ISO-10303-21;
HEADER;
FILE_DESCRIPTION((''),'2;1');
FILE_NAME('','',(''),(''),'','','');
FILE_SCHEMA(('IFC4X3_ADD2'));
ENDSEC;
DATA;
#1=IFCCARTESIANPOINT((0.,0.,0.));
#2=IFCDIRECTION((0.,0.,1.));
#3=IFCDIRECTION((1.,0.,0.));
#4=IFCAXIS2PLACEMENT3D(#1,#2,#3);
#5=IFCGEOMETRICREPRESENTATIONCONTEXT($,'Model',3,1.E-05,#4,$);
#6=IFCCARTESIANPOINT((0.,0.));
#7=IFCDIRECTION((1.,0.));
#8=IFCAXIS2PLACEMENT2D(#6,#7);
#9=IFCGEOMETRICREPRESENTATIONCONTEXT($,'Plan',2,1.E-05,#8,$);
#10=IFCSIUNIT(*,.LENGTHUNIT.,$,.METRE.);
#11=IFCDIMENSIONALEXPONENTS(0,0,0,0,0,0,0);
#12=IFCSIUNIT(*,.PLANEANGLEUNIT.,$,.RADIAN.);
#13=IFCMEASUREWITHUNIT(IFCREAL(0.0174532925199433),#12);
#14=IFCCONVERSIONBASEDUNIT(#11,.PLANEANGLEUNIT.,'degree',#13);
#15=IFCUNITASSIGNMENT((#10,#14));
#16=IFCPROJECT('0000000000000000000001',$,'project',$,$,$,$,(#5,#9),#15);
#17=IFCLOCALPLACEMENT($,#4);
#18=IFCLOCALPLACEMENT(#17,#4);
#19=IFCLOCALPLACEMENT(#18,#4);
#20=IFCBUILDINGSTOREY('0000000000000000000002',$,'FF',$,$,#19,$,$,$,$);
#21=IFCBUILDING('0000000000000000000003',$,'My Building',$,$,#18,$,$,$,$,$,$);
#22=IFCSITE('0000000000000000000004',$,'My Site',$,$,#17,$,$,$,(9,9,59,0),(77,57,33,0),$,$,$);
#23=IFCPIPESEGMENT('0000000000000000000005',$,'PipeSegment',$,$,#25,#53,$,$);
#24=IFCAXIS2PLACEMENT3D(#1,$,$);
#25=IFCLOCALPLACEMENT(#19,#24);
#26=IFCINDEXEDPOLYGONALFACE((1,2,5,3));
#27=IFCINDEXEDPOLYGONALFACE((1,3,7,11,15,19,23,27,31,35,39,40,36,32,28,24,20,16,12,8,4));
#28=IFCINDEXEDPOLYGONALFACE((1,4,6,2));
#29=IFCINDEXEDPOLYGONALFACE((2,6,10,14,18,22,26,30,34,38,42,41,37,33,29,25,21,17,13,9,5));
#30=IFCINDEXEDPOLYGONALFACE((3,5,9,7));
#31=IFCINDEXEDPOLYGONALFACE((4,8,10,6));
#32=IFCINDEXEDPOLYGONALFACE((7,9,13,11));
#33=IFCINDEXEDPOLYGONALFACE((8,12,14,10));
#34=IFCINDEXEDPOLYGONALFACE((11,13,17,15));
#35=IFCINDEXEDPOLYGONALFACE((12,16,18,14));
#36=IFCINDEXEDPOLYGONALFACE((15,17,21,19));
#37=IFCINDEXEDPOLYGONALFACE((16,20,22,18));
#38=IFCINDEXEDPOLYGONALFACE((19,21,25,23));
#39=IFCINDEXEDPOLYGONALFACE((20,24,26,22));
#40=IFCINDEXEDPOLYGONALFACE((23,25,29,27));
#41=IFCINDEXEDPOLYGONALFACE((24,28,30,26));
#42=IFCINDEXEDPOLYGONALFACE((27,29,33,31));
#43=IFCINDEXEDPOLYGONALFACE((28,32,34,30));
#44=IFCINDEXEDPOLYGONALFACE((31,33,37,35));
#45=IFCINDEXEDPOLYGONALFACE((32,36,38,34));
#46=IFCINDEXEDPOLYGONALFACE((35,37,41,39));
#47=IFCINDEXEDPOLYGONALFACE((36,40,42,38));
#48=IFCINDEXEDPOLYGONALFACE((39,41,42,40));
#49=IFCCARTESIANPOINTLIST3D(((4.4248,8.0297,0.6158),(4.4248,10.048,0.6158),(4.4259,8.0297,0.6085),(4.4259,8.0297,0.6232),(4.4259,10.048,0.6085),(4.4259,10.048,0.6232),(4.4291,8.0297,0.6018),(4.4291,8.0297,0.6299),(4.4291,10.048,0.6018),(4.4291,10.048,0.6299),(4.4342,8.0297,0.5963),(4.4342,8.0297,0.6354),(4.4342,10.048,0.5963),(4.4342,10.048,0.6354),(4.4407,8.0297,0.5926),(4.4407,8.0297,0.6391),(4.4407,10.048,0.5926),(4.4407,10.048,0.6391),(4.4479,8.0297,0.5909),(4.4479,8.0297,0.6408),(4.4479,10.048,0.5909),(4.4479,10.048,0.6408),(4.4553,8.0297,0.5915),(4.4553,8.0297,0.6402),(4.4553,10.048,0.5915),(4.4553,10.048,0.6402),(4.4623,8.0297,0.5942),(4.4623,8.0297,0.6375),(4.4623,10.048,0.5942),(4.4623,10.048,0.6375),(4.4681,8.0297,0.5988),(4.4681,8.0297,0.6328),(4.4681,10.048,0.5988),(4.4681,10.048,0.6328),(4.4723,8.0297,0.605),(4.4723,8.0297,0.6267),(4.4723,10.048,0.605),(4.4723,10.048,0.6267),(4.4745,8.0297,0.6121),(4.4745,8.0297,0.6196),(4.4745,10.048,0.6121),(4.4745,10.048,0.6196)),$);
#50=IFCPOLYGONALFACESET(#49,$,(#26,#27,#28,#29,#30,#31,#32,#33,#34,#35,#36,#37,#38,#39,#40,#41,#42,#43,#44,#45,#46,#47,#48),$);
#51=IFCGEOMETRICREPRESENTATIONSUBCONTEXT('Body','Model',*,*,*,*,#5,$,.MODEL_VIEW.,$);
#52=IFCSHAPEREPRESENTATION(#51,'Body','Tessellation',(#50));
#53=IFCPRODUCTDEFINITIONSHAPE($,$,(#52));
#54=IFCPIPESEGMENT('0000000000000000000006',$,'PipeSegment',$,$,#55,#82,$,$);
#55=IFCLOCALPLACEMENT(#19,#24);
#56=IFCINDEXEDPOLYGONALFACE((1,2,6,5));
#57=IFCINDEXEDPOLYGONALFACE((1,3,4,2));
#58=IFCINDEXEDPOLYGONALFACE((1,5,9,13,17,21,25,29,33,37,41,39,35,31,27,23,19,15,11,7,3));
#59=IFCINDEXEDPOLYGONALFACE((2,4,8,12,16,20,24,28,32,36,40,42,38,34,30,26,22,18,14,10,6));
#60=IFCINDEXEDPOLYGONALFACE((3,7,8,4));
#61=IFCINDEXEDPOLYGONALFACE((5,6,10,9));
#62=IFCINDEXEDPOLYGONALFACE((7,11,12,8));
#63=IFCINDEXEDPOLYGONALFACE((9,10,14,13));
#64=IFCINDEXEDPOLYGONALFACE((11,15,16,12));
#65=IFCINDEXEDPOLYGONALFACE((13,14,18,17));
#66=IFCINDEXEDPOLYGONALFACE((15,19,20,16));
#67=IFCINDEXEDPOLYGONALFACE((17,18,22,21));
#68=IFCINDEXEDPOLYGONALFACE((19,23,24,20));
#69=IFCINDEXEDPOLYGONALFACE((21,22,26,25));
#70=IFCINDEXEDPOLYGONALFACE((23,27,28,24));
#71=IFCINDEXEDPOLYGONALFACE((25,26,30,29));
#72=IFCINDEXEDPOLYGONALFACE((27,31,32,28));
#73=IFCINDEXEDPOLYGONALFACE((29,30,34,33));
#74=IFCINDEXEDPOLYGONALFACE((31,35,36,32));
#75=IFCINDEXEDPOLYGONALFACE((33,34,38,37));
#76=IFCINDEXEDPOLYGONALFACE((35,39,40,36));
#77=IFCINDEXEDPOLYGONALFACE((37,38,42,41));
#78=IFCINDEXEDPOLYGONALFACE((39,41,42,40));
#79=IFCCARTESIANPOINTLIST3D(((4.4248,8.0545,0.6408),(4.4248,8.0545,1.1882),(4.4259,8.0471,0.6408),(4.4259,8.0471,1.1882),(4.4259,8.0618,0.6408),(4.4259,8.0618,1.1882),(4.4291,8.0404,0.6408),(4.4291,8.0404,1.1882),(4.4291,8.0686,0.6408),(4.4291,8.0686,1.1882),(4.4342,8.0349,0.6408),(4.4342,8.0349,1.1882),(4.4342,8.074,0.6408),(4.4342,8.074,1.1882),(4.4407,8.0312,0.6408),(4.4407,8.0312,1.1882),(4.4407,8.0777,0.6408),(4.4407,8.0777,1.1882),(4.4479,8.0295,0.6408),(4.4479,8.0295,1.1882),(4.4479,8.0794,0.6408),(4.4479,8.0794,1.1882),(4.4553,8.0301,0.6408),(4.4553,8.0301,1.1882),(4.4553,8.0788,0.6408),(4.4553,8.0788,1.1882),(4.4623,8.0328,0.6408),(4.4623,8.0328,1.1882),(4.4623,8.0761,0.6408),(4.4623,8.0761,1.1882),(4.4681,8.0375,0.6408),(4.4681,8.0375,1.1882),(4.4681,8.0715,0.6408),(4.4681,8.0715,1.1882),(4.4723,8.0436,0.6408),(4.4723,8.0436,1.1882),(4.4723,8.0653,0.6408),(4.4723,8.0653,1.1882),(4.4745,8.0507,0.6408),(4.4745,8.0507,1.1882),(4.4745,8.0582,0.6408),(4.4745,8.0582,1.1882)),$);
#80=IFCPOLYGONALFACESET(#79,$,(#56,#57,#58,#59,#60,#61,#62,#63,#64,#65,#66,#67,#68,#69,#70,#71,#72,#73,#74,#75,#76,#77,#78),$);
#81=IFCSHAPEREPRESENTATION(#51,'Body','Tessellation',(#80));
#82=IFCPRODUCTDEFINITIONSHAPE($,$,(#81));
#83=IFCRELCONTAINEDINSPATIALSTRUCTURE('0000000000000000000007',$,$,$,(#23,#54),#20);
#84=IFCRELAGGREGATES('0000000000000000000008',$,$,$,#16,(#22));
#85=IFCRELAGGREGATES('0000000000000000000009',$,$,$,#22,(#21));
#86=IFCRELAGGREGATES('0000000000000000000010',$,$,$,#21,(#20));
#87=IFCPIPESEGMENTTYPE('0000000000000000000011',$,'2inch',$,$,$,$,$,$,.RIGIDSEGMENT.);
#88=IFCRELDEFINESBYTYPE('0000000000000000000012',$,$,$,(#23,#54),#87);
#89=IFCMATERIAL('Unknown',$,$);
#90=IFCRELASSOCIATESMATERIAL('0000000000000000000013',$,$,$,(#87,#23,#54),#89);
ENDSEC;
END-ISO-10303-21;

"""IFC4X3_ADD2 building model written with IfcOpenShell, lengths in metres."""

from ifc_helpers import new_model, entity, si_unit, converted_unit, frame, origin_with_axes, origin_2d_with_axis, place, context, subcontext, project, spatial, circle, extrude, material, material_profile, profile_set, profile_usage, type_object, element, save


model = new_model("IFC4X3_ADD2")

# Units and contexts
model_context = context("Model", 3, precision=1e-05, world=origin_with_axes())
plan_context = context("Plan", 2, precision=1e-05, world=origin_2d_with_axis())
body_context_1 = subcontext(model_context, "Body", "Model", "MODEL_VIEW")
ifc_project = project(units=[si_unit("LENGTHUNIT", "METRE"), converted_unit("PLANEANGLEUNIT", "degree", entity("IfcReal", 0.0174532925199433), si_unit("PLANEANGLEUNIT", "RADIAN"), dimensions=[0, 0, 0, 0, 0, 0, 0])], contexts=[model_context, plan_context])

# Site, building, storey
site_placement = place(None, origin_with_axes())
site = spatial("IfcSite", under=ifc_project, at=site_placement, Name="My Site", RefLatitude=(9, 9, 59, 0), RefLongitude=(77, 57, 33, 0))
building_placement = place(site_placement, origin_with_axes())
building = spatial("IfcBuilding", under=site, at=building_placement, Name="My Building")
storey_placement = place(building_placement, origin_with_axes())
storey = spatial("IfcBuildingStorey", under=building, at=storey_placement, Name="FF")

# Shared definitions
ifc_material = material(Name="Unknown")

# Pipe segments
ifc_material_profile_1 = material_profile(ifc_material, circle(Radius=0.025))
ifc_profile_set_1 = profile_set([ifc_material_profile_1])
pipe_segment_type_1 = type_object("IfcPipeSegmentType", Name="2inch", PredefinedType="RIGIDSEGMENT", material=ifc_profile_set_1)
ifc_profile_usage_1 = profile_usage(ifc_profile_set_1)
pipe_segment_1_placement = place(storey_placement, frame((4.4498, 8.0297, 0.6158), z_axis=(0.0, 1.0, 0.0), x_axis=(-1.0, 0.0, 0.0)))
element("IfcPipeSegment", 1, at=pipe_segment_1_placement, inside=storey, type_object=pipe_segment_type_1, material=ifc_profile_usage_1, Name="PipeSegment", context=body_context_1, shape_type="SweptSolid", body=[
    extrude(circle(Radius=0.025), origin_with_axes(), (0.0, 0.0, 1.0), 2.0184),
])
ifc_profile_usage_2 = profile_usage(ifc_profile_set_1)
pipe_segment_2_placement = place(storey_placement, frame((4.4498, 8.0545, 0.6408), z_axis=(0.0, 0.0, 1.0), x_axis=(-1.0, 0.0, 0.0)))
element("IfcPipeSegment", 2, at=pipe_segment_2_placement, inside=storey, type_object=pipe_segment_type_1, material=ifc_profile_usage_2, Name="PipeSegment", context=body_context_1, shape_type="SweptSolid", body=[
    extrude(circle(Radius=0.025), origin_with_axes(), (0.0, 0.0, 1.0), 0.5474),
])

save(model, "model.ifc")
